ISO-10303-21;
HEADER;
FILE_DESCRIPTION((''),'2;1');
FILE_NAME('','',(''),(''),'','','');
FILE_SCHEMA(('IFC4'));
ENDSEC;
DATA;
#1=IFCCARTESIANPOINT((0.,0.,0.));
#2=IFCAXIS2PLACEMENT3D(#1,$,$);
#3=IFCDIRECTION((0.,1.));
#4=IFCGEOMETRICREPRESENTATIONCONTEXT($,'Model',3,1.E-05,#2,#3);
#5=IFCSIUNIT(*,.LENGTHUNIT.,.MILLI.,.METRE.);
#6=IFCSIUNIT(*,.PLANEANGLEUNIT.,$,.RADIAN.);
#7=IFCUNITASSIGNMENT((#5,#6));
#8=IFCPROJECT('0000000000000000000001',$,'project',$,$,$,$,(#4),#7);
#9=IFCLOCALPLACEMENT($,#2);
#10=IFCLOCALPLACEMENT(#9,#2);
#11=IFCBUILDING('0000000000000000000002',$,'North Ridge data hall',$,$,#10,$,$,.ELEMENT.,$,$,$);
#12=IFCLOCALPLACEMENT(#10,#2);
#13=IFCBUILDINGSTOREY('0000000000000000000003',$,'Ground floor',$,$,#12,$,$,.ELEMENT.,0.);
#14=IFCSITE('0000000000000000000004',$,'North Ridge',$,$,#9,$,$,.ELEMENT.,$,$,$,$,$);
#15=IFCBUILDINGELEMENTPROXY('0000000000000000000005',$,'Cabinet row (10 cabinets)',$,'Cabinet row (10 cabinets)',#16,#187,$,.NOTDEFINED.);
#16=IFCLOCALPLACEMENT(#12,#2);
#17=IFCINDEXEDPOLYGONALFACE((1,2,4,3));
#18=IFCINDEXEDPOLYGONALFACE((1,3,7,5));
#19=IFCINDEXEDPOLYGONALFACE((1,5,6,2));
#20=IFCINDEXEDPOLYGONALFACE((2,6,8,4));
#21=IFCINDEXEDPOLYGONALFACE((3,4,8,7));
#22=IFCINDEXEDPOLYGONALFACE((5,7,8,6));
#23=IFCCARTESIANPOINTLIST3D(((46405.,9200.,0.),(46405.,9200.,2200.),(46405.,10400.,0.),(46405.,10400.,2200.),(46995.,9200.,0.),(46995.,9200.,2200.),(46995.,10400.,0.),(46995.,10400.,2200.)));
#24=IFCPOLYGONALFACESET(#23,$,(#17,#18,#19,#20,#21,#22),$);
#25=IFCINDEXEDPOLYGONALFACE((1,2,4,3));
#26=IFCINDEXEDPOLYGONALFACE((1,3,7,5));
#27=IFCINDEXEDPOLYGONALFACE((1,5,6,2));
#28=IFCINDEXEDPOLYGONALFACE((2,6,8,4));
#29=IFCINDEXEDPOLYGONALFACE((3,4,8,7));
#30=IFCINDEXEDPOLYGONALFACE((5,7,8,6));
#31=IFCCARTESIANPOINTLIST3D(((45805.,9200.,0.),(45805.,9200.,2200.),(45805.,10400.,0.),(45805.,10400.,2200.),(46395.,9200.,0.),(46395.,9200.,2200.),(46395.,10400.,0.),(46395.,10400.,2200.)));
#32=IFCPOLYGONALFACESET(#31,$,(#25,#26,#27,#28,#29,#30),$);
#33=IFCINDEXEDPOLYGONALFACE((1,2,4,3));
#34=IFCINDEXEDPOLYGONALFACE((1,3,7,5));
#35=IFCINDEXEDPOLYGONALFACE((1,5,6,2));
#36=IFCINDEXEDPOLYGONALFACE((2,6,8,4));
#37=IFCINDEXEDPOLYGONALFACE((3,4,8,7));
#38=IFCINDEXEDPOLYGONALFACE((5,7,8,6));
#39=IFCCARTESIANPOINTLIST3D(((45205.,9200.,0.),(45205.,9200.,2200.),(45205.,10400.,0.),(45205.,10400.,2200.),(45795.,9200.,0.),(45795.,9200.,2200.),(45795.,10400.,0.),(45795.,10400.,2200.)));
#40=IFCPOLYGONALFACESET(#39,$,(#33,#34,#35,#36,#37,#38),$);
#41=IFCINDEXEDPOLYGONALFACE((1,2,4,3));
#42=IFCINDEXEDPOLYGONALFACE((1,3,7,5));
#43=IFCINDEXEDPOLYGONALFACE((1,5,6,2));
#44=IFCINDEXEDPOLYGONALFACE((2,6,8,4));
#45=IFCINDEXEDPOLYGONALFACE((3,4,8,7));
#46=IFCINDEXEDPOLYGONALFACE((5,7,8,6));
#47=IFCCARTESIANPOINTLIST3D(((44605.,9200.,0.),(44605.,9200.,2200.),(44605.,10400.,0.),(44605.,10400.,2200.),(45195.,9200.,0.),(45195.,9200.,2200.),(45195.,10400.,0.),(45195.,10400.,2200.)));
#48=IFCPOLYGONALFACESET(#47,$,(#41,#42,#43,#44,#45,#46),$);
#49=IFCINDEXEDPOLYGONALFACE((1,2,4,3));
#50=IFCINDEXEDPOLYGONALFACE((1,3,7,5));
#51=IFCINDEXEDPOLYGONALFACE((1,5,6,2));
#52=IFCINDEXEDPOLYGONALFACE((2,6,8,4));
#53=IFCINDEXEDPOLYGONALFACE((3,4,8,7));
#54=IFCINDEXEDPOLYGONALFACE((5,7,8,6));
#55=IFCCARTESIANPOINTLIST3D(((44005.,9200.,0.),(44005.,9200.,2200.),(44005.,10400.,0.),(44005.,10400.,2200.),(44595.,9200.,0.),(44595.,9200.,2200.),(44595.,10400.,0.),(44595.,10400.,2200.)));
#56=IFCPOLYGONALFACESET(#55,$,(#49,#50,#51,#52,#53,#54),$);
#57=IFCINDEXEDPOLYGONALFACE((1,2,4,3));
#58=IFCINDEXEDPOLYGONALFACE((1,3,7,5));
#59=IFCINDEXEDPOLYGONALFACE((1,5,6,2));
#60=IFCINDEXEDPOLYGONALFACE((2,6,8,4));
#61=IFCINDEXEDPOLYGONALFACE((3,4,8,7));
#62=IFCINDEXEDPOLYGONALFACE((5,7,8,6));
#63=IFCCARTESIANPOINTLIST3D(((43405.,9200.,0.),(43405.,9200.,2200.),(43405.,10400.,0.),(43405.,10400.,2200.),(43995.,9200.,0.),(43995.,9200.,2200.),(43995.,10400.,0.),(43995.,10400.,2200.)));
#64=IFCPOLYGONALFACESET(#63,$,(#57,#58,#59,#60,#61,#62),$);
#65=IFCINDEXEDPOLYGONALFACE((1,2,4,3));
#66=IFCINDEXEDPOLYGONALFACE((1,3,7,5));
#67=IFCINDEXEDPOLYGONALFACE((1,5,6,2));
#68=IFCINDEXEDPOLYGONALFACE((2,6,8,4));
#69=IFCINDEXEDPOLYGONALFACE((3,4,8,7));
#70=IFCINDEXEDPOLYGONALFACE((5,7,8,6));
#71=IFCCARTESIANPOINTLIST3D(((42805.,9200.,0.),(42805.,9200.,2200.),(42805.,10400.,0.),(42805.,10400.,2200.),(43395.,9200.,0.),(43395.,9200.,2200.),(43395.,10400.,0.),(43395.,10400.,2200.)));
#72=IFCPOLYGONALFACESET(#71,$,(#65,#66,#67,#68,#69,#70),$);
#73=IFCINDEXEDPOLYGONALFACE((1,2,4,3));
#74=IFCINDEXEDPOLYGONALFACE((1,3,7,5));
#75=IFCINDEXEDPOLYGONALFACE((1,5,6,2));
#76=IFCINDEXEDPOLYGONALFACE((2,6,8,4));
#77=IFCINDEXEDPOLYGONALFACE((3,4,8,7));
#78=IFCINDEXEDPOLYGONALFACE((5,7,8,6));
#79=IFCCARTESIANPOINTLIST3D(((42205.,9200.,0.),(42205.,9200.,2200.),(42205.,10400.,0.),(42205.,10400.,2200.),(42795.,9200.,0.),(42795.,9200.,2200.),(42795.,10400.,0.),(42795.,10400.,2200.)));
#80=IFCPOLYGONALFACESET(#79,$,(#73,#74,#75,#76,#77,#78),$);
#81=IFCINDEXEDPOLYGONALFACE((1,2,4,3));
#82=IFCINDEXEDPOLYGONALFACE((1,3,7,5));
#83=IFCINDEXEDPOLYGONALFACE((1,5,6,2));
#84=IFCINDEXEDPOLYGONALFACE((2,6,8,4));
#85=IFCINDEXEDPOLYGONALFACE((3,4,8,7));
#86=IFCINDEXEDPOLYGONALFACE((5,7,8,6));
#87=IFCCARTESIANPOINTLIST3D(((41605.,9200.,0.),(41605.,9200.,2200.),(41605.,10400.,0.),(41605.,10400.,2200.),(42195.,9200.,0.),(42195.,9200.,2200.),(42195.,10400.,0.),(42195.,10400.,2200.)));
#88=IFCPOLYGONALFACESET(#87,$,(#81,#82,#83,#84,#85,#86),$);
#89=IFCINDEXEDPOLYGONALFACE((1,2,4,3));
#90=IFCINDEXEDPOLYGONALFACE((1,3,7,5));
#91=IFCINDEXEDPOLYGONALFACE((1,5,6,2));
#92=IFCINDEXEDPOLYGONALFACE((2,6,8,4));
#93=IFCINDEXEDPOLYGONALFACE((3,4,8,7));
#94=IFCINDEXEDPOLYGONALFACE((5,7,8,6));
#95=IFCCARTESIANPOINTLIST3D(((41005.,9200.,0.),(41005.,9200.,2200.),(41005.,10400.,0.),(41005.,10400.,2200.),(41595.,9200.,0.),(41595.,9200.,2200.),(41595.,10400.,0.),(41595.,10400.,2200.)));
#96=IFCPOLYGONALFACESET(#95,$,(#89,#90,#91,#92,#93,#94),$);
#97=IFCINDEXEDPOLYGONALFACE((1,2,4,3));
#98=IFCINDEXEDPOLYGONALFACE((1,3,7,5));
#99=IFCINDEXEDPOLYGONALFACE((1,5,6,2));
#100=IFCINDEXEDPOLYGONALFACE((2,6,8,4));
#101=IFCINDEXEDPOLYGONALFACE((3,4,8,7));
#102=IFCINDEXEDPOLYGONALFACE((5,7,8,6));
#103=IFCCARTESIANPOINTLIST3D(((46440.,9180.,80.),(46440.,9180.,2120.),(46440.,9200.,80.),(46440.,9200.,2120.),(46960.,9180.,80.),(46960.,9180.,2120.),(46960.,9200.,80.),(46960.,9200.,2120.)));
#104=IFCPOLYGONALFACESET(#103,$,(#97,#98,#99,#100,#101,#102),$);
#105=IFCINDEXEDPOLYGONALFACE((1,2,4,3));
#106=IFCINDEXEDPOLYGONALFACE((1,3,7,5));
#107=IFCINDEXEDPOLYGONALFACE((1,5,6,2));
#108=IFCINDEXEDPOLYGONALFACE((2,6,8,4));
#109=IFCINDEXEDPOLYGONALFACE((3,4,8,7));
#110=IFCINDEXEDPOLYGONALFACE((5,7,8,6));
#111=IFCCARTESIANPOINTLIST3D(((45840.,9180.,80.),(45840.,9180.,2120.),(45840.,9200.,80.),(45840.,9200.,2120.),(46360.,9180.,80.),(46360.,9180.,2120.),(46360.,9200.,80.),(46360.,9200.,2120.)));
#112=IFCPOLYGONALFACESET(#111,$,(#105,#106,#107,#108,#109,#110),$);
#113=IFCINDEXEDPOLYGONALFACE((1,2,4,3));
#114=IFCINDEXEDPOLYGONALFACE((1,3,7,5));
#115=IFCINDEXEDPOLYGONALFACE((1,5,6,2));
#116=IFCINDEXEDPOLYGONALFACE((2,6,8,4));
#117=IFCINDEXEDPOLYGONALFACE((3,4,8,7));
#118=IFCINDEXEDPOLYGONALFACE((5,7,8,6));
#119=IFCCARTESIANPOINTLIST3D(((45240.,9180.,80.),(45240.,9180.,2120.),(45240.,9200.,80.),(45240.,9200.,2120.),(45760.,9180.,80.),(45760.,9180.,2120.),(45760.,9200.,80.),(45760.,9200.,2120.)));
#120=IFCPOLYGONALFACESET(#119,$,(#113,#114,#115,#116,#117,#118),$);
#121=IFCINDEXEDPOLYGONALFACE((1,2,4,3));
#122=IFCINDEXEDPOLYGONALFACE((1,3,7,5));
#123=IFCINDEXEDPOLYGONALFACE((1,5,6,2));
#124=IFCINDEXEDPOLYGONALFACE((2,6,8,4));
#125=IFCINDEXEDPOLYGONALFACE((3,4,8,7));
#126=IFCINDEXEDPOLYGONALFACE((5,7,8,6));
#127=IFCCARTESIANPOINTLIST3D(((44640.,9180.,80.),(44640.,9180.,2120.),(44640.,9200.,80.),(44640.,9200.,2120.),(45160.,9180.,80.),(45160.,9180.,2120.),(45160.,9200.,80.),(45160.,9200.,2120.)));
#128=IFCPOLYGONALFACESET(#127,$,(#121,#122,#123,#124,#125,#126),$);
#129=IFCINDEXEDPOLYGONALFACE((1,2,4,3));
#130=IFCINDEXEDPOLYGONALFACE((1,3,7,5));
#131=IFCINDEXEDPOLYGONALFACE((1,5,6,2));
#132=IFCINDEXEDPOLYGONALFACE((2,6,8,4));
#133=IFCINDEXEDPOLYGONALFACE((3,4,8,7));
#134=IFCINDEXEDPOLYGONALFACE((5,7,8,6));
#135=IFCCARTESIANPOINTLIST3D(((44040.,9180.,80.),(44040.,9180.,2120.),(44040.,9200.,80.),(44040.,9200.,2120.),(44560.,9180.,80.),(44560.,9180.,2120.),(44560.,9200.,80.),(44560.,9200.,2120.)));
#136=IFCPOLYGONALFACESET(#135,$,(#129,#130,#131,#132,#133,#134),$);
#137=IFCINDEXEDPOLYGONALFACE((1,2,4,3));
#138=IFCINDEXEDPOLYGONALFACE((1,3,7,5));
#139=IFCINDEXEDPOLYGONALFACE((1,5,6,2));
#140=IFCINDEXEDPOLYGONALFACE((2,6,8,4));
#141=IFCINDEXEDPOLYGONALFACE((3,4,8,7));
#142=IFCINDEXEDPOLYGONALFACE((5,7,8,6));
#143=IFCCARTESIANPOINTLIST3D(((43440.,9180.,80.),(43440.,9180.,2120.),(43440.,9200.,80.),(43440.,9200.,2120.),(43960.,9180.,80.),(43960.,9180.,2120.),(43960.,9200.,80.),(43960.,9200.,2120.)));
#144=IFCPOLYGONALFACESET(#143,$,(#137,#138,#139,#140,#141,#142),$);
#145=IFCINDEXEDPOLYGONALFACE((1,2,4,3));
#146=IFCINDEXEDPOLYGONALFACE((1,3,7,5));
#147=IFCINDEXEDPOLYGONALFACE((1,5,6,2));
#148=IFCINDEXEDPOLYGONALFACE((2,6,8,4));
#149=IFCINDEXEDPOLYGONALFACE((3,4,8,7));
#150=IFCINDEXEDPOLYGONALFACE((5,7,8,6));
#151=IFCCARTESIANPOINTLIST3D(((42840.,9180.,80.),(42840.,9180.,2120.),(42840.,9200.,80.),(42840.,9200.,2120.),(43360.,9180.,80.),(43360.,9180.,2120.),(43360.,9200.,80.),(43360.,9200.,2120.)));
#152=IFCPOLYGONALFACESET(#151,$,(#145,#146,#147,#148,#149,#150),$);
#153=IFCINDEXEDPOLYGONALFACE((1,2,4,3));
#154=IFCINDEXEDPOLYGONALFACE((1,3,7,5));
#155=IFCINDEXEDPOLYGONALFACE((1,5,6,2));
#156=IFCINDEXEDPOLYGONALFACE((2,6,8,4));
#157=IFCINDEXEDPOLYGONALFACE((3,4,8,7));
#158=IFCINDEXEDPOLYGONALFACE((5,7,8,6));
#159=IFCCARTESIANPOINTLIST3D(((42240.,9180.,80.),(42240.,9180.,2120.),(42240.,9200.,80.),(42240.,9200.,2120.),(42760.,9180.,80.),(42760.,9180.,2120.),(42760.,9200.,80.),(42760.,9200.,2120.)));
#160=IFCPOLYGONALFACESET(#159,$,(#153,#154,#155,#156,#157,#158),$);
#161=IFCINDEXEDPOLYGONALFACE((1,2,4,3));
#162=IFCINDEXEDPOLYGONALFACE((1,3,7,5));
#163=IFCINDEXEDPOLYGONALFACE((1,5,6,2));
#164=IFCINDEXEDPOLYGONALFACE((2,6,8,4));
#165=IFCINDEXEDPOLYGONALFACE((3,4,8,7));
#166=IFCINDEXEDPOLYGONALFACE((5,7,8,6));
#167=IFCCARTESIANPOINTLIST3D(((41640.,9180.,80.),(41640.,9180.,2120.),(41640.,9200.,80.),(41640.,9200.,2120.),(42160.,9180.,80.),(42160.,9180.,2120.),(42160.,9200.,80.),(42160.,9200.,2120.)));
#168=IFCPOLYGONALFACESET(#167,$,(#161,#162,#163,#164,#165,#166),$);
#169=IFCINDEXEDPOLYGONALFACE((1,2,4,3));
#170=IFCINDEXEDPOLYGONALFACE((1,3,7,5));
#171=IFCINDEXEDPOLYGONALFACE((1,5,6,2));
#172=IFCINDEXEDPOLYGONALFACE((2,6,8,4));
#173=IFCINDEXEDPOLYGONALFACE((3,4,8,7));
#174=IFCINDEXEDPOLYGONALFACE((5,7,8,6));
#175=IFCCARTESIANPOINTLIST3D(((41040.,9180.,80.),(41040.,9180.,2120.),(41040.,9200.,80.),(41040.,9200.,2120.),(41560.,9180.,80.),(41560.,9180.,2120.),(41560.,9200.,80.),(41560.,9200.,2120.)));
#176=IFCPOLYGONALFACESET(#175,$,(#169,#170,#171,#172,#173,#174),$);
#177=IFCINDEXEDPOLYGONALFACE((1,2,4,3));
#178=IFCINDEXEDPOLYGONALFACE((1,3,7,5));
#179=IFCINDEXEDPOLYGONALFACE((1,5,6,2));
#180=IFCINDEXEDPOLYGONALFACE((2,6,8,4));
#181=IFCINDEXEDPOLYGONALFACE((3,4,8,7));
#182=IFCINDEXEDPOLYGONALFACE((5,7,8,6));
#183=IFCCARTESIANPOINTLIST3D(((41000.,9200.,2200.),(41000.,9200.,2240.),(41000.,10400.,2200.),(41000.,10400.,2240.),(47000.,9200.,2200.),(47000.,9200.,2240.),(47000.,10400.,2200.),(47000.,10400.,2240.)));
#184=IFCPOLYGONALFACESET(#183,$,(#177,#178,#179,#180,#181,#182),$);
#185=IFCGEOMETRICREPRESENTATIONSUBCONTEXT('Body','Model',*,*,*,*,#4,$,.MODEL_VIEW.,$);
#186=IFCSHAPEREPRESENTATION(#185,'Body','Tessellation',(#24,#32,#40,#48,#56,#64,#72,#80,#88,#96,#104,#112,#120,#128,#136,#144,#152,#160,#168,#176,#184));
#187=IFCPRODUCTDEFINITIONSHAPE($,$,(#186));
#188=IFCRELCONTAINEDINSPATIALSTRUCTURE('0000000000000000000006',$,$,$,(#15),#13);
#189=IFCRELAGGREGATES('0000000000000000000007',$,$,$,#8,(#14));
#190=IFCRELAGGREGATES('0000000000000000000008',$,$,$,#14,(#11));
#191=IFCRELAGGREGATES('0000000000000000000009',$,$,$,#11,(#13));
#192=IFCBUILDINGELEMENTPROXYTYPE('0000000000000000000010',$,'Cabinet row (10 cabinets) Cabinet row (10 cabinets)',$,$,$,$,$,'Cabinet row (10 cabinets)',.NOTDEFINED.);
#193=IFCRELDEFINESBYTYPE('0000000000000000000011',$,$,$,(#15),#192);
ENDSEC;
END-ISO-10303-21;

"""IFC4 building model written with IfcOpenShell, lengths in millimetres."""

from ifc_helpers import new_model, si_unit, direction, frame, origin, place, context, subcontext, project, spatial, polyline, outline, extrude, source, transform, mapped, type_object, type_shapes, element, save


model = new_model("IFC4")

# Units and contexts
model_context = context("Model", 3, precision=1e-05, world=origin(), true_north=direction((0.0, 1.0)))
body_context = subcontext(model_context, "Body", "Model", "MODEL_VIEW")
ifc_project = project(units=[si_unit("LENGTHUNIT", "METRE", prefix="MILLI"), si_unit("PLANEANGLEUNIT", "RADIAN")], contexts=[model_context])

# Site, building, storey
site_placement = place(None, origin())
site = spatial("IfcSite", under=ifc_project, at=site_placement, Name="North Ridge", CompositionType="ELEMENT")
building_placement = place(site_placement, origin())
building = spatial("IfcBuilding", under=site, at=building_placement, Name="North Ridge data hall", CompositionType="ELEMENT")
storey_placement = place(building_placement, origin())
storey = spatial("IfcBuildingStorey", under=building, at=storey_placement, Name="Ground floor", CompositionType="ELEMENT", Elevation=0.0)

# Building element proxy
building_element_proxy_type_1 = type_object("IfcBuildingElementProxyType", Name="Cabinet row (10 cabinets) Cabinet row (10 cabinets)", ElementType="Cabinet row (10 cabinets)", PredefinedType="NOTDEFINED")
shared_shape_1 = source(origin(), body_context, "Body", "SweptSolid", [
    extrude(outline(polyline([(5.0, 0.0), (595.0, 0.0), (595.0, 1200.0), (5.0, 1200.0), (5.0, 0.0)])), origin(), (0.0, 0.0, 1.0), 2200.0),
    extrude(outline(polyline([(605.0, 0.0), (1195.0, 0.0), (1195.0, 1200.0), (605.0, 1200.0), (605.0, 0.0)])), origin(), (0.0, 0.0, 1.0), 2200.0),
    extrude(outline(polyline([(1205.0, 0.0), (1795.0, 0.0), (1795.0, 1200.0), (1205.0, 1200.0), (1205.0, 0.0)])), origin(), (0.0, 0.0, 1.0), 2200.0),
    extrude(outline(polyline([(1805.0, 0.0), (2395.0, 0.0), (2395.0, 1200.0), (1805.0, 1200.0), (1805.0, 0.0)])), origin(), (0.0, 0.0, 1.0), 2200.0),
    extrude(outline(polyline([(2405.0, 0.0), (2995.0, 0.0), (2995.0, 1200.0), (2405.0, 1200.0), (2405.0, 0.0)])), origin(), (0.0, 0.0, 1.0), 2200.0),
    extrude(outline(polyline([(3005.0, 0.0), (3595.0, 0.0), (3595.0, 1200.0), (3005.0, 1200.0), (3005.0, 0.0)])), origin(), (0.0, 0.0, 1.0), 2200.0),
    extrude(outline(polyline([(3605.0, 0.0), (4195.0, 0.0), (4195.0, 1200.0), (3605.0, 1200.0), (3605.0, 0.0)])), origin(), (0.0, 0.0, 1.0), 2200.0),
    extrude(outline(polyline([(4205.0, 0.0), (4795.0, 0.0), (4795.0, 1200.0), (4205.0, 1200.0), (4205.0, 0.0)])), origin(), (0.0, 0.0, 1.0), 2200.0),
    extrude(outline(polyline([(4805.0, 0.0), (5395.0, 0.0), (5395.0, 1200.0), (4805.0, 1200.0), (4805.0, 0.0)])), origin(), (0.0, 0.0, 1.0), 2200.0),
    extrude(outline(polyline([(5405.0, 0.0), (5995.0, 0.0), (5995.0, 1200.0), (5405.0, 1200.0), (5405.0, 0.0)])), origin(), (0.0, 0.0, 1.0), 2200.0),
    extrude(outline(polyline([(40.0, 1200.0), (560.0, 1200.0), (560.0, 1220.0), (40.0, 1220.0), (40.0, 1200.0)])), frame((0.0, 0.0, 80.0)), (0.0, 0.0, 1.0), 2040.0),
    extrude(outline(polyline([(640.0, 1200.0), (1160.0, 1200.0), (1160.0, 1220.0), (640.0, 1220.0), (640.0, 1200.0)])), frame((0.0, 0.0, 80.0)), (0.0, 0.0, 1.0), 2040.0),
    extrude(outline(polyline([(1240.0, 1200.0), (1760.0, 1200.0), (1760.0, 1220.0), (1240.0, 1220.0), (1240.0, 1200.0)])), frame((0.0, 0.0, 80.0)), (0.0, 0.0, 1.0), 2040.0),
    extrude(outline(polyline([(1840.0, 1200.0), (2360.0, 1200.0), (2360.0, 1220.0), (1840.0, 1220.0), (1840.0, 1200.0)])), frame((0.0, 0.0, 80.0)), (0.0, 0.0, 1.0), 2040.0),
    extrude(outline(polyline([(2440.0, 1200.0), (2960.0, 1200.0), (2960.0, 1220.0), (2440.0, 1220.0), (2440.0, 1200.0)])), frame((0.0, 0.0, 80.0)), (0.0, 0.0, 1.0), 2040.0),
    extrude(outline(polyline([(3040.0, 1200.0), (3560.0, 1200.0), (3560.0, 1220.0), (3040.0, 1220.0), (3040.0, 1200.0)])), frame((0.0, 0.0, 80.0)), (0.0, 0.0, 1.0), 2040.0),
    extrude(outline(polyline([(3640.0, 1200.0), (4160.0, 1200.0), (4160.0, 1220.0), (3640.0, 1220.0), (3640.0, 1200.0)])), frame((0.0, 0.0, 80.0)), (0.0, 0.0, 1.0), 2040.0),
    extrude(outline(polyline([(4240.0, 1200.0), (4760.0, 1200.0), (4760.0, 1220.0), (4240.0, 1220.0), (4240.0, 1200.0)])), frame((0.0, 0.0, 80.0)), (0.0, 0.0, 1.0), 2040.0),
    extrude(outline(polyline([(4840.0, 1200.0), (5360.0, 1200.0), (5360.0, 1220.0), (4840.0, 1220.0), (4840.0, 1200.0)])), frame((0.0, 0.0, 80.0)), (0.0, 0.0, 1.0), 2040.0),
    extrude(outline(polyline([(5440.0, 1200.0), (5960.0, 1200.0), (5960.0, 1220.0), (5440.0, 1220.0), (5440.0, 1200.0)])), frame((0.0, 0.0, 80.0)), (0.0, 0.0, 1.0), 2040.0),
    extrude(outline(polyline([(0.0, 0.0), (6000.0, 0.0), (6000.0, 1200.0), (0.0, 1200.0), (0.0, 0.0)])), frame((0.0, 0.0, 2200.0)), (0.0, 0.0, 1.0), 40.0),
])
type_shapes(building_element_proxy_type_1, [shared_shape_1])
for number, where, z_axis, x_axis, name in (
    (1, (47000.0, 10400.0, 0.0), (0.0, 0.0, 1.0), (-1.0, 0.0, 0.0), "Cabinet row (10 cabinets)"),
):
    element("IfcBuildingElementProxy", number, at=place(storey_placement, frame(where, z_axis=z_axis, x_axis=x_axis)), inside=storey, type_object=building_element_proxy_type_1, Name=name, ObjectType="Cabinet row (10 cabinets)", PredefinedType="NOTDEFINED", context=body_context, shape_type="MappedRepresentation", body=[
        mapped(shared_shape_1, transform((0.0, 0.0, 0.0))),
    ])

save(model, "model.ifc")
